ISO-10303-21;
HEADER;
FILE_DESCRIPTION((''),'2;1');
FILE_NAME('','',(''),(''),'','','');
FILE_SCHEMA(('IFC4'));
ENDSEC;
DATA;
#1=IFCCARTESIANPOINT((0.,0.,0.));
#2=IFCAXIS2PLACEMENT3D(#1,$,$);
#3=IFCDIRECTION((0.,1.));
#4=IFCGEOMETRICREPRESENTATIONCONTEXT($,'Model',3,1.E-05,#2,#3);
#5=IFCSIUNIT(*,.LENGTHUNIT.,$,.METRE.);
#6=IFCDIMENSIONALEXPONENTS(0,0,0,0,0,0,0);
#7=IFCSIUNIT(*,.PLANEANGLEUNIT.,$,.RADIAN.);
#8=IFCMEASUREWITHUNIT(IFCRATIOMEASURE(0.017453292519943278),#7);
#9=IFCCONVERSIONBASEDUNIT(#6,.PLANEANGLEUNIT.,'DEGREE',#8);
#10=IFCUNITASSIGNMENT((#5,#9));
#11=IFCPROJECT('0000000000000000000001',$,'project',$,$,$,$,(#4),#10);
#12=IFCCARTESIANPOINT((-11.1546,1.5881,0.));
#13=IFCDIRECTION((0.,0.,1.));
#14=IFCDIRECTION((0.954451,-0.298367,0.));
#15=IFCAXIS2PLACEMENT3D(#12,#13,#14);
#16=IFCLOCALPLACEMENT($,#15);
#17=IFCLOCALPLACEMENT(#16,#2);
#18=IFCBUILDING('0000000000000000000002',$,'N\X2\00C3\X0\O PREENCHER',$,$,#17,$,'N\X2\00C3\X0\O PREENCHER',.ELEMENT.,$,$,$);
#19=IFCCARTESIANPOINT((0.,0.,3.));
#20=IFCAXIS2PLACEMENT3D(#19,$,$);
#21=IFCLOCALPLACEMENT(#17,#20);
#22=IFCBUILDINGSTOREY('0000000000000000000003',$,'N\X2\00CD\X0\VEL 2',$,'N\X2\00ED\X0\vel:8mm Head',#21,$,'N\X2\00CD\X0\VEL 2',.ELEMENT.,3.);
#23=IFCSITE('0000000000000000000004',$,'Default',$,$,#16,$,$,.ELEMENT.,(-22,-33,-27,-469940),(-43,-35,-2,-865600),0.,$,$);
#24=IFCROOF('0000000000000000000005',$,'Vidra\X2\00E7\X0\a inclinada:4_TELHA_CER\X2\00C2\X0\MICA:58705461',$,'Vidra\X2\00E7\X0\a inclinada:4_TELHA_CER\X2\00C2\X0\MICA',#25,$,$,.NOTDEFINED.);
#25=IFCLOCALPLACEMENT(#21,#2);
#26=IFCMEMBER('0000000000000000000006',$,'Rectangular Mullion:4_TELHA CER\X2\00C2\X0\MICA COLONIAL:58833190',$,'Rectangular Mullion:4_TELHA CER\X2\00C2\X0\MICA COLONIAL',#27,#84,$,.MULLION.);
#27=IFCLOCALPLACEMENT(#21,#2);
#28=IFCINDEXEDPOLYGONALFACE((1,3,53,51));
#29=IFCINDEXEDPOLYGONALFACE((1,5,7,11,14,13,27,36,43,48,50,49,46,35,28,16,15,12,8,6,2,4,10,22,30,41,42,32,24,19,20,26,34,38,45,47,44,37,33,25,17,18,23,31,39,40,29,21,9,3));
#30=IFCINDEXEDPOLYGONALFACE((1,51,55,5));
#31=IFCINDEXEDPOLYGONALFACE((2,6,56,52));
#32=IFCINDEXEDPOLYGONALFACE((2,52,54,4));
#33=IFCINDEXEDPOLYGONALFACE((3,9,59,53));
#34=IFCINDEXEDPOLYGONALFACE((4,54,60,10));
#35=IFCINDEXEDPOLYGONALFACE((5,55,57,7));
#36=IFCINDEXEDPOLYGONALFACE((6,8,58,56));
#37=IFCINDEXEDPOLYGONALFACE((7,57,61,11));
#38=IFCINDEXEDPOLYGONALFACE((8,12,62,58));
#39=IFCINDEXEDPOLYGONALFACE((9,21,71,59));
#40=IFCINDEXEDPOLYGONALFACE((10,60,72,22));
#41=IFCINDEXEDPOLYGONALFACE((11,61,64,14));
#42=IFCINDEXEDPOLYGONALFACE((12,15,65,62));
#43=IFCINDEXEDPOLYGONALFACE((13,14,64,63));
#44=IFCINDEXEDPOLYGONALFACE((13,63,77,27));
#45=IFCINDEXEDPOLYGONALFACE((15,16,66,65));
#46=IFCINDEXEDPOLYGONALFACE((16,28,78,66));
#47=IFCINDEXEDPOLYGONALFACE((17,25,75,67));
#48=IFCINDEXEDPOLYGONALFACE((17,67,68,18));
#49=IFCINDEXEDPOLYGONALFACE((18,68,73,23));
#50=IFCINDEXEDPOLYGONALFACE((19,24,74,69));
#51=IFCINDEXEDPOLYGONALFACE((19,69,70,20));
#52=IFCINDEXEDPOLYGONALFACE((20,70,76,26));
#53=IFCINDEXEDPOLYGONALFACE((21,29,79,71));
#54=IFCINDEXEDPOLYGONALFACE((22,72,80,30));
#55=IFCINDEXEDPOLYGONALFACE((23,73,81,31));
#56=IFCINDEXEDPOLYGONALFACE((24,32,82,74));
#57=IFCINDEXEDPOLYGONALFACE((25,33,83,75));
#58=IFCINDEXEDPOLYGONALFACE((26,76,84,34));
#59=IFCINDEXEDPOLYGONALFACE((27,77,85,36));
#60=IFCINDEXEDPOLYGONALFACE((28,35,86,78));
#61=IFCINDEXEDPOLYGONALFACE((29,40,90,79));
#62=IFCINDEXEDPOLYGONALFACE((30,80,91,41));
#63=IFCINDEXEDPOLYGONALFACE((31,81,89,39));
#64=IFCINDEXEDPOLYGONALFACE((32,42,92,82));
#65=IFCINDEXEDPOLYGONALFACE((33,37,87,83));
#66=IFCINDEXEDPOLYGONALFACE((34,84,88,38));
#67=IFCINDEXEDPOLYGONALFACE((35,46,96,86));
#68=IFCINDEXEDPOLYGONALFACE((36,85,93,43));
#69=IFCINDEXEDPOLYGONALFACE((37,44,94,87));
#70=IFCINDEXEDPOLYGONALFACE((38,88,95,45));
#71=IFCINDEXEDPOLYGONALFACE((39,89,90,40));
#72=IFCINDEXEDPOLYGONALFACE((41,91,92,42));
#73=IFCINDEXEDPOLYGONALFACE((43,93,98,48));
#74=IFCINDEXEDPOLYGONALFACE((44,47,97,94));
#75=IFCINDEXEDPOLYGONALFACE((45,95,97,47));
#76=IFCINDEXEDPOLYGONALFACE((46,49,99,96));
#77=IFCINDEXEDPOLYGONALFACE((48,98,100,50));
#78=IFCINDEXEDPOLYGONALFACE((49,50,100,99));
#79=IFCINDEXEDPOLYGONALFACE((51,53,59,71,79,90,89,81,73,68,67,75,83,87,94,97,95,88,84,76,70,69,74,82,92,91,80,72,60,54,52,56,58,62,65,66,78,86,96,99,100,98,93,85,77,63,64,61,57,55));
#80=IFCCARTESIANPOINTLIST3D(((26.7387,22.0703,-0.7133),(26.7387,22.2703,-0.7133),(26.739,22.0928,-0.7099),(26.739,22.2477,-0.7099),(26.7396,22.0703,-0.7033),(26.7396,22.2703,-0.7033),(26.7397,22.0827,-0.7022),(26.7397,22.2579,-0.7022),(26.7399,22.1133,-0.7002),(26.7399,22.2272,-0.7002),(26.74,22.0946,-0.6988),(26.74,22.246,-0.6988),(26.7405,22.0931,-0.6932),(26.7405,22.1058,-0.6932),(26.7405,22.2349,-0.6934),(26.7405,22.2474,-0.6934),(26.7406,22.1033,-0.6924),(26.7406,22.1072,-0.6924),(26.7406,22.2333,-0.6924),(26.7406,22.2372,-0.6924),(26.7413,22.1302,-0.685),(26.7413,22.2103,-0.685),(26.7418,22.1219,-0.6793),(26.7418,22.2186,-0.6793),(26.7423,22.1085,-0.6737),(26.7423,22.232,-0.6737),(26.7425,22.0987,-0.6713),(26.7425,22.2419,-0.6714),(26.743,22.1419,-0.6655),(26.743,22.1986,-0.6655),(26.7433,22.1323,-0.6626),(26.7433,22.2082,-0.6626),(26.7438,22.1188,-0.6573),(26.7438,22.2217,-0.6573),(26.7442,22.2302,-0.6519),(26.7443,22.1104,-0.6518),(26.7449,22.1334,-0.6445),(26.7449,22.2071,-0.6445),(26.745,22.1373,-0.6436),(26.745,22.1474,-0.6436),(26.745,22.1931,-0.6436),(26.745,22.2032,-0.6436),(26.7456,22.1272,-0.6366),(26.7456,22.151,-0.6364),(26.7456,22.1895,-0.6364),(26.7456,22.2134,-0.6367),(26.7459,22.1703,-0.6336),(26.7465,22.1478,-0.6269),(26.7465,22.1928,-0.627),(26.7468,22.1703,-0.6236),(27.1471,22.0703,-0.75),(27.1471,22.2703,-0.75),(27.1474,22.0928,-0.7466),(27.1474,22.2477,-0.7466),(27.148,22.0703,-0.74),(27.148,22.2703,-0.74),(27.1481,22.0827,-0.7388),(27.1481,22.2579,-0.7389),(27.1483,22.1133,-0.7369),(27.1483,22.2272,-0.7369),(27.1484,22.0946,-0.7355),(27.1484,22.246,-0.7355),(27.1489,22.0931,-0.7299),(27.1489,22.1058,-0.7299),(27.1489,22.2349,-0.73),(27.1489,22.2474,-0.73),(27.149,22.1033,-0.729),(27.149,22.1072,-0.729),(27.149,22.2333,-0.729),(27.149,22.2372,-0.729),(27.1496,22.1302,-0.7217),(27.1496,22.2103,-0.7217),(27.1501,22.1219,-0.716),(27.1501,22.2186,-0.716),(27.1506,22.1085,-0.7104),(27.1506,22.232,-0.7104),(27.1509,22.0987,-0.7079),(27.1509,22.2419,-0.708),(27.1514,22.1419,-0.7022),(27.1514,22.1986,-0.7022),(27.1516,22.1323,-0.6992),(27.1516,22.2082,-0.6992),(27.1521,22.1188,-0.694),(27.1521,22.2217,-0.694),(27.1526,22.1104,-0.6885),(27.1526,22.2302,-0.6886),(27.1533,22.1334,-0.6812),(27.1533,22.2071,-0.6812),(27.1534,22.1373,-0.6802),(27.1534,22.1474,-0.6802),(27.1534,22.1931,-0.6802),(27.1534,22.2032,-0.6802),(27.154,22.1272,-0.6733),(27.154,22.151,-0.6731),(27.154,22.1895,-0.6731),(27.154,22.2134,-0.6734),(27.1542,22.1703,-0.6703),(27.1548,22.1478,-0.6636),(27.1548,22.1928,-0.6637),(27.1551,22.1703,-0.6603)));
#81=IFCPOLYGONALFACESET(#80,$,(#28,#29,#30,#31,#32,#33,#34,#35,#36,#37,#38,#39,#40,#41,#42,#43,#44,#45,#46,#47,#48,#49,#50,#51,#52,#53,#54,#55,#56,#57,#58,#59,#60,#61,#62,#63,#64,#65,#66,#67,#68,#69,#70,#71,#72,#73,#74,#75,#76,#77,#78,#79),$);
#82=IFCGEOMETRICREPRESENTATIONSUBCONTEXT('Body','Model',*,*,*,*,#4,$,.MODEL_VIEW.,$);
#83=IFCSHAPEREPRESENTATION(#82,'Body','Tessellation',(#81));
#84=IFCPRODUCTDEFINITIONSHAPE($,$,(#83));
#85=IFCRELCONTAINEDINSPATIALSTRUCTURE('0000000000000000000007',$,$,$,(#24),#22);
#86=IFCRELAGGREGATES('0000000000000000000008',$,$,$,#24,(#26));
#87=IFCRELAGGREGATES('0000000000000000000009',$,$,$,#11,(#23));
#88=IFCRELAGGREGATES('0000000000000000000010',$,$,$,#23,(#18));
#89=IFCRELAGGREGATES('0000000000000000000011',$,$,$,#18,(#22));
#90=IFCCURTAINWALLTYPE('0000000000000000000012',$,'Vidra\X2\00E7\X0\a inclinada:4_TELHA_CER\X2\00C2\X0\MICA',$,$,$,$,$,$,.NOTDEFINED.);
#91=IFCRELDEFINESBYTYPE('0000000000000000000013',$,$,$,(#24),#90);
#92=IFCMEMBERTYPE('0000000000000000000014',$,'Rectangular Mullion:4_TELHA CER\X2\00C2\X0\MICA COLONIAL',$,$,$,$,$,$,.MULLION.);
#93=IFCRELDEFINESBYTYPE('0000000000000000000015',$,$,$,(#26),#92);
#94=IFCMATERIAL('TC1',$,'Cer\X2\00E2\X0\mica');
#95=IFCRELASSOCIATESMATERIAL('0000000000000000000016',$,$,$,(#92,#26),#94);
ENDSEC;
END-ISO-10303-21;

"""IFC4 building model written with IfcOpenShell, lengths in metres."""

from ifc_helpers import new_model, entity, si_unit, converted_unit, direction, frame, origin, place, context, subcontext, project, spatial, line, arc, indexed_curve, outline, extrude, source, transform, mapped, material, type_object, type_shapes, element, aggregate, save


model = new_model("IFC4")

# Units and contexts
model_context = context("Model", 3, precision=1e-05, world=origin(), true_north=direction((0.0, 1.0)))
body_context = subcontext(model_context, "Body", "Model", "MODEL_VIEW")
ifc_project = project(units=[si_unit("LENGTHUNIT", "METRE"), converted_unit("PLANEANGLEUNIT", "DEGREE", entity("IfcRatioMeasure", 0.017453292519943278), si_unit("PLANEANGLEUNIT", "RADIAN"), dimensions=[0, 0, 0, 0, 0, 0, 0])], contexts=[model_context])

# Site, building, storey
site_placement = place(None, frame((-11.1546, 1.5881, 0.0), z_axis=(0.0, 0.0, 1.0), x_axis=(0.954451, -0.298367, 0.0)))
site = spatial("IfcSite", under=ifc_project, at=site_placement, Name="Default", CompositionType="ELEMENT", RefLatitude=(-22, -33, -27, -469940), RefLongitude=(-43, -35, -2, -865600), RefElevation=0.0)
building_placement = place(site_placement, origin())
building = spatial("IfcBuilding", under=site, at=building_placement, Name="NÃO PREENCHER", LongName="NÃO PREENCHER", CompositionType="ELEMENT")
storey_placement = place(building_placement, frame((0.0, 0.0, 3.0)))
storey = spatial("IfcBuildingStorey", under=building, at=storey_placement, Name="NÍVEL 2", ObjectType="Nível:8mm Head", LongName="NÍVEL 2", CompositionType="ELEMENT", Elevation=3.0)

# Roof, member
curtain_wall_type = type_object("IfcCurtainWallType", Name="Vidraça inclinada:4_TELHA_CERÂMICA", PredefinedType="NOTDEFINED")
roof_placement = place(storey_placement, frame((0.0, 0.0, -3.0)))
roof = element("IfcRoof", 1, at=roof_placement, inside=storey, type_object=curtain_wall_type, Name="Vidraça inclinada:4_TELHA_CERÂMICA:58705461", ObjectType="Vidraça inclinada:4_TELHA_CERÂMICA", PredefinedType="NOTDEFINED")
ifc_material = material(Name="TC1", Category="Cerâmica")
member_type_1 = type_object("IfcMemberType", Name="Rectangular Mullion:4_TELHA CERÂMICA COLONIAL", PredefinedType="MULLION", material=ifc_material)
shared_shape_1 = source(origin(), body_context, "Body", "SweptSolid", [
    extrude(outline(indexed_curve([(-0.029, -0.1), (-0.019, -0.1), (-0.0164, -0.0815), (-0.0089, -0.0645), (-0.0089, -0.0771), (0.061, 0.0), (-0.009, 0.0771), (-0.009, 0.0646), (-0.0165, 0.0816), (-0.019, 0.1), (-0.029, 0.1), (-0.0089, 0.0479), (0.041, 0.0229), (0.041, 0.0329), (0.0131, 0.0425), (-0.008, 0.0631), (-0.008, 0.067), (0.051, 0.0), (-0.008, -0.067), (-0.008, -0.0631), (0.0131, -0.0425), (0.041, -0.0329), (0.041, -0.0229), (-0.0089, -0.0479)], segments=[line(1, 2), arc(2, 3, 4), line(4, 5), arc(5, 6, 7), line(7, 8), arc(8, 9, 10), line(10, 11), arc(11, 12, 13), line(13, 14), arc(14, 15, 16), line(16, 17), arc(17, 18, 19), line(19, 20), arc(20, 21, 22), line(22, 23), arc(23, 24, 1)], self_intersect=False)), frame((0.0, -0.029, -0.41), z_axis=(0.0, 0.0, 1.0), x_axis=(0.0, -1.0, 0.0)), (0.0, 0.0, 1.0), 0.41),
])
type_shapes(member_type_1, [shared_shape_1])
member_1_placement = place(roof_placement, frame((26.7387, 22.1703, 2.2867), z_axis=(-0.99599, 0.0, 0.089469), x_axis=(0.0, 1.0, 0.0)))
member_1 = element("IfcMember", 2, at=member_1_placement, type_object=member_type_1, material=ifc_material, Name="Rectangular Mullion:4_TELHA CERÂMICA COLONIAL:58833190", ObjectType="Rectangular Mullion:4_TELHA CERÂMICA COLONIAL", PredefinedType="MULLION", context=body_context, shape_type="MappedRepresentation", body=[
    mapped(shared_shape_1, transform((0.0, 0.0, 0.0), scale=1.0)),
])
aggregate(roof, [member_1])

save(model, "model.ifc")
